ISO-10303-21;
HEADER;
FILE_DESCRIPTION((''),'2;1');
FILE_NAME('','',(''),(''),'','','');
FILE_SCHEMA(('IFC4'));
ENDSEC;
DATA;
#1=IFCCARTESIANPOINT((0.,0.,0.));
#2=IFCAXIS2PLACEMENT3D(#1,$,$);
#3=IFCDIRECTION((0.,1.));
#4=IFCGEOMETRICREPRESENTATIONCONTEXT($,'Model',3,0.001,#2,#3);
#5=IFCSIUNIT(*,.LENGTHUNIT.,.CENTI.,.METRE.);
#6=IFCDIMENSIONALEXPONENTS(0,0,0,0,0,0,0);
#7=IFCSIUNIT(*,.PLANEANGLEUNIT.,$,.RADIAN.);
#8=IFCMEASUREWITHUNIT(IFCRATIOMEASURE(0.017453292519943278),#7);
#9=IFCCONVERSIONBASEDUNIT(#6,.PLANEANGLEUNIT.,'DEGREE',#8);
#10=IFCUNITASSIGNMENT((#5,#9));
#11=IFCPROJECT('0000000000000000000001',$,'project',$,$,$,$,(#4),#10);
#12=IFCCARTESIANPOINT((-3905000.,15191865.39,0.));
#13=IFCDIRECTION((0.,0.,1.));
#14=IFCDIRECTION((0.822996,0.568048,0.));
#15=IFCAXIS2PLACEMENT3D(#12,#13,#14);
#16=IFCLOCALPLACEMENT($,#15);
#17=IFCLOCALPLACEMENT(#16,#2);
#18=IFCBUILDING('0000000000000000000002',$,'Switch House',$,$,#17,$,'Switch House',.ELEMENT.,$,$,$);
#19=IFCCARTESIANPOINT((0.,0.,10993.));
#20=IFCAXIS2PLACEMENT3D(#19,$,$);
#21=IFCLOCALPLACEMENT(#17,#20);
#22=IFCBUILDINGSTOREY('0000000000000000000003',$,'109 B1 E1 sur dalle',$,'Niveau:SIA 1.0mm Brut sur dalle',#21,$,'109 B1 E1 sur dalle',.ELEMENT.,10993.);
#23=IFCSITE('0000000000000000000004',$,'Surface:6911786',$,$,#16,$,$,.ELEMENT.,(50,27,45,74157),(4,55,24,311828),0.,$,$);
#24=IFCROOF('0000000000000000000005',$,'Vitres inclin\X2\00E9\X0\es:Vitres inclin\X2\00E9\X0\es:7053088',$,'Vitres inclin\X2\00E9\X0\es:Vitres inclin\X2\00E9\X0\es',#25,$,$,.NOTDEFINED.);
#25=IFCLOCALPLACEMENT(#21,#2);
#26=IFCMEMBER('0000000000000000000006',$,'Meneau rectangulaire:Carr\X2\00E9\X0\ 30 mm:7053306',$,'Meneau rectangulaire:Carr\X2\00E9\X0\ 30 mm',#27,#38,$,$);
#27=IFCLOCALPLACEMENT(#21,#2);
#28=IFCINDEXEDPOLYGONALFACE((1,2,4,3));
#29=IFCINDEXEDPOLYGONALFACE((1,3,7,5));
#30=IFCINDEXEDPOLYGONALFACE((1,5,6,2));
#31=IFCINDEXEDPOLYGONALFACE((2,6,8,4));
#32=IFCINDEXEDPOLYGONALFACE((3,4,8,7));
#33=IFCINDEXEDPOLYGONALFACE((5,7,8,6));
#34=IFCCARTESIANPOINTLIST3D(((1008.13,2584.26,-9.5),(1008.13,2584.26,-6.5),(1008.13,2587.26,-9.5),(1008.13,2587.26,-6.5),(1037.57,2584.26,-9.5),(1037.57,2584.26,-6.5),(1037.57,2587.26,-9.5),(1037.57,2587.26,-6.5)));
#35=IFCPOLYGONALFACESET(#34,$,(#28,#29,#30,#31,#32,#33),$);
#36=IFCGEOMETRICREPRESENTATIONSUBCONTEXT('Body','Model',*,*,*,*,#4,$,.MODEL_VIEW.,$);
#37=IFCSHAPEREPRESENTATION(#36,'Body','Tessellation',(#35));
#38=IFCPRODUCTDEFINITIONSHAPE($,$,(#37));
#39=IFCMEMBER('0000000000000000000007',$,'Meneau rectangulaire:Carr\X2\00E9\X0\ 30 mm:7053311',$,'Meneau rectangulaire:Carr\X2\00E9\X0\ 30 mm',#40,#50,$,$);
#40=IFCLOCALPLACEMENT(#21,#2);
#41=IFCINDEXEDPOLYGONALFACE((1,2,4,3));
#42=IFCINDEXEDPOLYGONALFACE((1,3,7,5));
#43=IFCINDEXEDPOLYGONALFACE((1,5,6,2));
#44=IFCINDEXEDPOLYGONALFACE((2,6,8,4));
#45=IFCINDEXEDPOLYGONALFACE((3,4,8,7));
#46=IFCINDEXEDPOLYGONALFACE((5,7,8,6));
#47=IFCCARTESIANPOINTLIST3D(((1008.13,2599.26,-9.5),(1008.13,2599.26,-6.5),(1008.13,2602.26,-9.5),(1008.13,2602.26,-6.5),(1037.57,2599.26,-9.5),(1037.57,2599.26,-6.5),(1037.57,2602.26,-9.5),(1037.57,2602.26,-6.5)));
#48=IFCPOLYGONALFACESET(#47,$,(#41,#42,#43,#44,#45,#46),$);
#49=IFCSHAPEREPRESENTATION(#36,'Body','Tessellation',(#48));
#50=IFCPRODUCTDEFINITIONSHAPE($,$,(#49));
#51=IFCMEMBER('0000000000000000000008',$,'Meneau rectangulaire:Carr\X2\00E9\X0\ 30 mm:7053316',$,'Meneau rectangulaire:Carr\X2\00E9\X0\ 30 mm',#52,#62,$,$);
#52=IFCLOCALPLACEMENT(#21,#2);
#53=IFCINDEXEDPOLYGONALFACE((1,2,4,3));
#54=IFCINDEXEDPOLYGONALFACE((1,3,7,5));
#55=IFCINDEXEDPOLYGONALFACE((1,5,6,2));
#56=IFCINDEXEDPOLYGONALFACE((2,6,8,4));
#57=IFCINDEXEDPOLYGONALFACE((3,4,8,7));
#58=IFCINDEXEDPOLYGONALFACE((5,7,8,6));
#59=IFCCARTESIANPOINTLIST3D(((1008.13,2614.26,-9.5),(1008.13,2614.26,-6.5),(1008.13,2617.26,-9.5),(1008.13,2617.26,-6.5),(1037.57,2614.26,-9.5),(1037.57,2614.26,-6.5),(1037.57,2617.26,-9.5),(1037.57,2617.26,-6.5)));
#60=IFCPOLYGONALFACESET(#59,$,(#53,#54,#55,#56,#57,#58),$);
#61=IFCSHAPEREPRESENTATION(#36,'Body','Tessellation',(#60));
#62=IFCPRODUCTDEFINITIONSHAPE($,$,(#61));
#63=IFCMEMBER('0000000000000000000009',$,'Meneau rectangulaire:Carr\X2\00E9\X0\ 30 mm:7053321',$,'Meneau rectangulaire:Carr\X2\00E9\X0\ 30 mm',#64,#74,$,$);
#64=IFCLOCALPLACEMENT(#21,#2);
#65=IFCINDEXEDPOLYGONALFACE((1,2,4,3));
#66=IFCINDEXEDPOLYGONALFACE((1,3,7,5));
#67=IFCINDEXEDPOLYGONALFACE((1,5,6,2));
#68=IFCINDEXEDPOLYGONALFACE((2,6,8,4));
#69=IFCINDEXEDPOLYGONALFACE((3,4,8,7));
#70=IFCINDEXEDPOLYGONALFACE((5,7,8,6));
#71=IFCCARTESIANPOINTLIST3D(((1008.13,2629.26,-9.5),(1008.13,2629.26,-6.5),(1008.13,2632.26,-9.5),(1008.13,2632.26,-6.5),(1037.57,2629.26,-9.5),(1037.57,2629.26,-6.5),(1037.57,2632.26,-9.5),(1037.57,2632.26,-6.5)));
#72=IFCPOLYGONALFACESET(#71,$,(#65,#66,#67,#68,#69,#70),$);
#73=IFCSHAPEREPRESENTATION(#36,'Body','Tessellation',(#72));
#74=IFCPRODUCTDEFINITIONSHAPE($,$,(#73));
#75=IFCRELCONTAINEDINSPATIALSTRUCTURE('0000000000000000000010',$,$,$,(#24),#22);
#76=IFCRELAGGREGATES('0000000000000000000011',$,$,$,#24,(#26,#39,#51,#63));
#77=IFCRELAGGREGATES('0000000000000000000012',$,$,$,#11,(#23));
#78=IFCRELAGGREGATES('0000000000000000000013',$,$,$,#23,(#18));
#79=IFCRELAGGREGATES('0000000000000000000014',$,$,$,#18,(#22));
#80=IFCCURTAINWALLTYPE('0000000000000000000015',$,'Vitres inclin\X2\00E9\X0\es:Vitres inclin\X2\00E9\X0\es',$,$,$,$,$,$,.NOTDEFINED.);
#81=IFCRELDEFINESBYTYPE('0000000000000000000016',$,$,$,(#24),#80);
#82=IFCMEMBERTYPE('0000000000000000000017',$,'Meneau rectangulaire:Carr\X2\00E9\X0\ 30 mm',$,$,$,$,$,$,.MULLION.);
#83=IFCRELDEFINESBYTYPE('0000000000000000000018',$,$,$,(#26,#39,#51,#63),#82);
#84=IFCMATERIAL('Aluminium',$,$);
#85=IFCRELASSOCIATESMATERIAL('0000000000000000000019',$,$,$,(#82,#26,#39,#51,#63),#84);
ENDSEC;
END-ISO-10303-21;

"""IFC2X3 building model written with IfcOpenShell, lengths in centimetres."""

from ifc_helpers import new_model, entity, si_unit, converted_unit, direction, frame, origin, origin_2d_with_axis, place, context, subcontext, project, spatial, rectangle, extrude, source, transform, mapped, material, type_object, type_shapes, element, aggregate, save


model = new_model("IFC2X3")

# Units and contexts
model_context = context("Model", 3, precision=0.001, world=origin(), true_north=direction((0.0, 1.0)))
body_context = subcontext(model_context, "Body", "Model", "MODEL_VIEW")
ifc_project = project(units=[si_unit("LENGTHUNIT", "METRE", prefix="CENTI"), converted_unit("PLANEANGLEUNIT", "DEGREE", entity("IfcRatioMeasure", 0.017453292519943278), si_unit("PLANEANGLEUNIT", "RADIAN"), dimensions=[0, 0, 0, 0, 0, 0, 0])], contexts=[model_context])

# Site, building, storey
site_placement = place(None, frame((-3905000.0, 15191865.39, 0.0), z_axis=(0.0, 0.0, 1.0), x_axis=(0.822996, 0.568048, 0.0)))
site = spatial("IfcSite", under=ifc_project, at=site_placement, Name="Surface:6911786", CompositionType="ELEMENT", RefLatitude=(50, 27, 45, 74157), RefLongitude=(4, 55, 24, 311828), RefElevation=0.0)
building_placement = place(site_placement, origin())
building = spatial("IfcBuilding", under=site, at=building_placement, Name="Switch House", LongName="Switch House", CompositionType="ELEMENT")
storey_placement = place(building_placement, frame((0.0, 0.0, 10993.0)))
storey = spatial("IfcBuildingStorey", under=building, at=storey_placement, Name="109 B1 E1 sur dalle", ObjectType="Niveau:SIA 1.0mm Brut sur dalle", LongName="109 B1 E1 sur dalle", CompositionType="ELEMENT", Elevation=10993.0)

# Roof, members
curtain_wall_type = type_object("IfcCurtainWallType", Name="Vitres inclinées:Vitres inclinées", PredefinedType="NOTDEFINED")
roof_placement = place(storey_placement, frame((0.0, 0.0, -10993.0)))
roof = element("IfcRoof", 1, at=roof_placement, inside=storey, type_object=curtain_wall_type, Name="Vitres inclinées:Vitres inclinées:7053088", ObjectType="Vitres inclinées:Vitres inclinées", ShapeType="NOTDEFINED")
ifc_material = material(Name="Aluminium")
member_type_1 = type_object("IfcMemberType", Name="Meneau rectangulaire:Carré 30 mm", PredefinedType="MULLION", material=ifc_material)
shared_shape_1 = source(origin(), body_context, "Body", "SweptSolid", [
    extrude(rectangle(XDim=3.0, YDim=3.0, at=origin_2d_with_axis()), frame((0.0, 0.0, -29.44), z_axis=(0.0, 0.0, 1.0), x_axis=(0.0, -1.0, 0.0)), (0.0, 0.0, 1.0), 29.44),
])
type_shapes(member_type_1, [shared_shape_1])
member_1_placement = place(roof_placement, frame((1008.13, 2585.76, 10985.0), z_axis=(-1.0, 0.0, 0.0), x_axis=(0.0, 1.0, 0.0)))
member_1 = element("IfcMember", 2, at=member_1_placement, type_object=member_type_1, material=ifc_material, Name="Meneau rectangulaire:Carré 30 mm:7053306", ObjectType="Meneau rectangulaire:Carré 30 mm", context=body_context, shape_type="MappedRepresentation", body=[
    mapped(shared_shape_1, transform((0.0, 0.0, 0.0), scale=1.0)),
])
member_2_placement = place(roof_placement, frame((1008.13, 2600.76, 10985.0), z_axis=(-1.0, 0.0, 0.0), x_axis=(0.0, 1.0, 0.0)))
member_2 = element("IfcMember", 3, at=member_2_placement, type_object=member_type_1, material=ifc_material, Name="Meneau rectangulaire:Carré 30 mm:7053311", ObjectType="Meneau rectangulaire:Carré 30 mm", context=body_context, shape_type="MappedRepresentation", body=[
    mapped(shared_shape_1, transform((0.0, 0.0, 0.0), scale=1.0)),
])
member_3_placement = place(roof_placement, frame((1008.13, 2615.76, 10985.0), z_axis=(-1.0, 0.0, 0.0), x_axis=(0.0, 1.0, 0.0)))
member_3 = element("IfcMember", 4, at=member_3_placement, type_object=member_type_1, material=ifc_material, Name="Meneau rectangulaire:Carré 30 mm:7053316", ObjectType="Meneau rectangulaire:Carré 30 mm", context=body_context, shape_type="MappedRepresentation", body=[
    mapped(shared_shape_1, transform((0.0, 0.0, 0.0), scale=1.0)),
])
member_4_placement = place(roof_placement, frame((1008.13, 2630.76, 10985.0), z_axis=(-1.0, 0.0, 0.0), x_axis=(0.0, 1.0, 0.0)))
member_4 = element("IfcMember", 5, at=member_4_placement, type_object=member_type_1, material=ifc_material, Name="Meneau rectangulaire:Carré 30 mm:7053321", ObjectType="Meneau rectangulaire:Carré 30 mm", context=body_context, shape_type="MappedRepresentation", body=[
    mapped(shared_shape_1, transform((0.0, 0.0, 0.0), scale=1.0)),
])
aggregate(roof, [member_1, member_2, member_3, member_4])

save(model, "model.ifc")
